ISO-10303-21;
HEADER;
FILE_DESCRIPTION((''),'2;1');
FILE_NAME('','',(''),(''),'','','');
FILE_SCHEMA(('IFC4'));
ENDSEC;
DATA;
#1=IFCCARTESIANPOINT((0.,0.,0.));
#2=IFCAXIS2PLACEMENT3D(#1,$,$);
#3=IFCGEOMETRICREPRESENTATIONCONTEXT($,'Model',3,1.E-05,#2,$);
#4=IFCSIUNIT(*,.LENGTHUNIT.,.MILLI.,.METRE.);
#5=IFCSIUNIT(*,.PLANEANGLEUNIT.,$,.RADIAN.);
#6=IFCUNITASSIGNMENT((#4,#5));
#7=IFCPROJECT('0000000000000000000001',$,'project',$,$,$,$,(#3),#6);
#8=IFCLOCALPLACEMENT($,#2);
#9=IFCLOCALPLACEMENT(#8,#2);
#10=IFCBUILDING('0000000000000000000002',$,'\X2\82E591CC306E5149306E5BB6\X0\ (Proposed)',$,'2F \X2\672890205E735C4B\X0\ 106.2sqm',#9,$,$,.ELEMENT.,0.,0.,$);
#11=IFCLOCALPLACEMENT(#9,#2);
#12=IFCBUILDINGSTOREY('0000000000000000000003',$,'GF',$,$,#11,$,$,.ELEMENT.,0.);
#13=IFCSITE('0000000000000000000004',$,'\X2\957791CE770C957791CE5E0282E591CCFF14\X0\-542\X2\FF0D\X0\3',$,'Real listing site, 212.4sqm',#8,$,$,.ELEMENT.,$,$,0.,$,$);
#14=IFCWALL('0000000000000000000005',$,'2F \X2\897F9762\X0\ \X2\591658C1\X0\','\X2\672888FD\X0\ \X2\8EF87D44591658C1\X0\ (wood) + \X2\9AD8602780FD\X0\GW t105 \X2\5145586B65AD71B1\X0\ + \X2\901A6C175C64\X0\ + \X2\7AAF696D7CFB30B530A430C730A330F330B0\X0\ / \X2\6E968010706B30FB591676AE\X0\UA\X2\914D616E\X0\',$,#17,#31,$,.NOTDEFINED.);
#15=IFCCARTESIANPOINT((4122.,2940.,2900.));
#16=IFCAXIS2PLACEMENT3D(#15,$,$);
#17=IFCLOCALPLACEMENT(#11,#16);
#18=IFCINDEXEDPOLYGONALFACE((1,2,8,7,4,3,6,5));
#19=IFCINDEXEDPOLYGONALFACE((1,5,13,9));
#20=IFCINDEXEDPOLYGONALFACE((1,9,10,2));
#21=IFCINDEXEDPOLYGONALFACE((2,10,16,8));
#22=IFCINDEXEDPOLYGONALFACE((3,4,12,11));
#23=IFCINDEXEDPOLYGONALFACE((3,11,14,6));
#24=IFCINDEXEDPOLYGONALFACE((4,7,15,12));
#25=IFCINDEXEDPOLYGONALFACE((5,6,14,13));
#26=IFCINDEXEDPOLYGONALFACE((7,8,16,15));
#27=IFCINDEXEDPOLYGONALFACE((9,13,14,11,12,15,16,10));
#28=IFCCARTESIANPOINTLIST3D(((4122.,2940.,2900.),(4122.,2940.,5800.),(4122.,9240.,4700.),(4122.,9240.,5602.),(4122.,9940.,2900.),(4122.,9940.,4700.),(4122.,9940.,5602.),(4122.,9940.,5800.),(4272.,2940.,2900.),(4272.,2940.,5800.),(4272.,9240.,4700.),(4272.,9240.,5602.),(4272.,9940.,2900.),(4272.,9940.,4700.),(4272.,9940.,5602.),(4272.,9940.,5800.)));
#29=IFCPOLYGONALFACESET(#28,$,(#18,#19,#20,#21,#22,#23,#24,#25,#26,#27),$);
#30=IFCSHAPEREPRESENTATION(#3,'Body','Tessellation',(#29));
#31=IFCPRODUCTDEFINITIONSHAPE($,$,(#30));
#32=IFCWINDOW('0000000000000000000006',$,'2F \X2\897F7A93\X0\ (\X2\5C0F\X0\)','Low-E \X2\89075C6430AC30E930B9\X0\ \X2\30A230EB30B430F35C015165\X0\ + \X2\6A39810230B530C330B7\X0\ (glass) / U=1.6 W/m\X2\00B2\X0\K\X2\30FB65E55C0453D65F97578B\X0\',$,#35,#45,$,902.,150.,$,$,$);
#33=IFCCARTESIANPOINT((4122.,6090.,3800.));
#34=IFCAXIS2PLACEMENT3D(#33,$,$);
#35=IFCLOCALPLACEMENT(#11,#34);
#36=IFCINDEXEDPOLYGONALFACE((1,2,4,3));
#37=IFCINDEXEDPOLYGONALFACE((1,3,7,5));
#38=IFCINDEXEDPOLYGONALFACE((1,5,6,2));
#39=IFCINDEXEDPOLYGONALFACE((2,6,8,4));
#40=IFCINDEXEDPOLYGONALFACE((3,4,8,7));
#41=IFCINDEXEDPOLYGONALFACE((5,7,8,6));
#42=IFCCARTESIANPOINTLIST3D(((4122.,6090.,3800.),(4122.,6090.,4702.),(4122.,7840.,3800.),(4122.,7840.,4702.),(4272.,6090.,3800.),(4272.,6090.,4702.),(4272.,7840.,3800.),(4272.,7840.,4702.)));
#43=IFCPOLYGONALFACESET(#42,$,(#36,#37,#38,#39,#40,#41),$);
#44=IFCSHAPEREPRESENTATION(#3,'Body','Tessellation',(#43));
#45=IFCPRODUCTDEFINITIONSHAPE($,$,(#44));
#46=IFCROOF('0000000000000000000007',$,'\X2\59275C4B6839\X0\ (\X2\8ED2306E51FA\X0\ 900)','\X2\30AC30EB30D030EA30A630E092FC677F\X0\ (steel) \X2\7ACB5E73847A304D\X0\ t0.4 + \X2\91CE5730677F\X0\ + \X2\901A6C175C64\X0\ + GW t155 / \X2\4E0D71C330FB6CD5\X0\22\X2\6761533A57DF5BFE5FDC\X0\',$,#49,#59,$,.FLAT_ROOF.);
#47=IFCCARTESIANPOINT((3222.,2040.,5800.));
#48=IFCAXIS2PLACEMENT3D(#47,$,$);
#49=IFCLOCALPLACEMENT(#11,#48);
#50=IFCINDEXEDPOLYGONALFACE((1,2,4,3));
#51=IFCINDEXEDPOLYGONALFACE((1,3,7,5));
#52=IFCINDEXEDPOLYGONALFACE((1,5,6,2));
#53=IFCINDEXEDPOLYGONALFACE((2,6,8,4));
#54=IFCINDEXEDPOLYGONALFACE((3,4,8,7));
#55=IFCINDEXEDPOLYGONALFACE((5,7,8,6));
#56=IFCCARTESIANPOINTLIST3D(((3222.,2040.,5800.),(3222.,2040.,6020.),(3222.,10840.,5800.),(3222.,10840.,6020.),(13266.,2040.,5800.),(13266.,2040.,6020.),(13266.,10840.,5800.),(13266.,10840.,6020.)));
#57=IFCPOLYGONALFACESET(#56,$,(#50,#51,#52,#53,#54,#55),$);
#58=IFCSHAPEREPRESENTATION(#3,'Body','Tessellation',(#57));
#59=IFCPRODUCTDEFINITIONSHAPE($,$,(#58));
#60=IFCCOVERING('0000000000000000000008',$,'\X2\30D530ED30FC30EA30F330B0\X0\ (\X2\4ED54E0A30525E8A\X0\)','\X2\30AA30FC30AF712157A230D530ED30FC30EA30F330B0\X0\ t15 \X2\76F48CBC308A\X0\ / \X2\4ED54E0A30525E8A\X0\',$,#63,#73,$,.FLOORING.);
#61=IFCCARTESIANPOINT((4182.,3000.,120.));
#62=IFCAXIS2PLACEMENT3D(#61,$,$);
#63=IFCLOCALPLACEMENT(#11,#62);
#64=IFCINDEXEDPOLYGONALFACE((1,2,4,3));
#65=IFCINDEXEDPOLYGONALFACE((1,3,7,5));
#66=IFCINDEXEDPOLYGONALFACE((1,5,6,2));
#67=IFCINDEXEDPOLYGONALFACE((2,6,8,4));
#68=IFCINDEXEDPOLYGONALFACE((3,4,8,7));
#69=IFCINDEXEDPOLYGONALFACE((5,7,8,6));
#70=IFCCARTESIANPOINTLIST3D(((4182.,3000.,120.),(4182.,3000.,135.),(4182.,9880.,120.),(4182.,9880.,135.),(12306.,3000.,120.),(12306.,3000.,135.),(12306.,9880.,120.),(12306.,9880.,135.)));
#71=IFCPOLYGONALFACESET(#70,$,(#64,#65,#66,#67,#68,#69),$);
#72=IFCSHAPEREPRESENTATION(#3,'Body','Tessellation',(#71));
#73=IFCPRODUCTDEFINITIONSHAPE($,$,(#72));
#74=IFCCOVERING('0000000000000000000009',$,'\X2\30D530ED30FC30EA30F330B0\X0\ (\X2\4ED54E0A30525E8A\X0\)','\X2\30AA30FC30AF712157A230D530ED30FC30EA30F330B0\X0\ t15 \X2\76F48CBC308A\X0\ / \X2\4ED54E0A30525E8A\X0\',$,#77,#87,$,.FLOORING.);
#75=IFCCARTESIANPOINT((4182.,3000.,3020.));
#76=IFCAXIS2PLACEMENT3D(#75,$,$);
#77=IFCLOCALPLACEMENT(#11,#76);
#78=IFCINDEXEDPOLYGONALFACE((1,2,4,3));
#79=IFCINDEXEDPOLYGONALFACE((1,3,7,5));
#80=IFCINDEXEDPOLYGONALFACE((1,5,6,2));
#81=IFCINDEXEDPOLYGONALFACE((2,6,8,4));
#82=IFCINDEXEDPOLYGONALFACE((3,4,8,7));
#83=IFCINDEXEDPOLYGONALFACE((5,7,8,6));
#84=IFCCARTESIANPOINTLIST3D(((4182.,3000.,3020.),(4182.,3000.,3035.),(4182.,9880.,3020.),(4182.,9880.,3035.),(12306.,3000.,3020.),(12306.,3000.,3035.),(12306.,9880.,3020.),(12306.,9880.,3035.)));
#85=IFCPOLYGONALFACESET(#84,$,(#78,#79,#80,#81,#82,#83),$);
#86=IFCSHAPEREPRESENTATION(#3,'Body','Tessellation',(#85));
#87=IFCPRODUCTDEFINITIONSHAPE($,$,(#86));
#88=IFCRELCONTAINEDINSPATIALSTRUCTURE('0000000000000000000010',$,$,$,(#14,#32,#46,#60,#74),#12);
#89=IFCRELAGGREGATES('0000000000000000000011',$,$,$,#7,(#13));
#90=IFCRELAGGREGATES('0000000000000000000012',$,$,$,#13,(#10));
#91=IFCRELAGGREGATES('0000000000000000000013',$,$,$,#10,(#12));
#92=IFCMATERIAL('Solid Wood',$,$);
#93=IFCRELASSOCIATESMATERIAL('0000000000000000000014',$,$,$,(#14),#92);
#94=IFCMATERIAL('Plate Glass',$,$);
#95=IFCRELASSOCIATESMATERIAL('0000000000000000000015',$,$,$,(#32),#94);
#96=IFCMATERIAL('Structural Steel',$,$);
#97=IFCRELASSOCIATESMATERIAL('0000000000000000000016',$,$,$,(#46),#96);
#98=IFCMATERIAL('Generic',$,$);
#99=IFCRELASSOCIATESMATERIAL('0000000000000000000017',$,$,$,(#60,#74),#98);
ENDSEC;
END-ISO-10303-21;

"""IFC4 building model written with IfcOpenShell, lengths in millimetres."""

from ifc_helpers import new_model, si_unit, frame, frame_2d, origin, place, context, project, spatial, rectangle, extrude, material, element, fill, save


model = new_model("IFC4")

# Units and contexts
model_context = context("Model", 3, precision=1e-05, world=origin())
ifc_project = project(units=[si_unit("LENGTHUNIT", "METRE", prefix="MILLI"), si_unit("PLANEANGLEUNIT", "RADIAN")], contexts=[model_context])

# Site, building, storey
site_placement = place(None, origin())
site = spatial("IfcSite", under=ifc_project, at=site_placement, Name="長野県長野市若里４-542－3", ObjectType="Real listing site, 212.4sqm", CompositionType="ELEMENT", RefElevation=0.0)
building_placement = place(site_placement, origin())
building = spatial("IfcBuilding", under=site, at=building_placement, Name="若里の光の家 (Proposed)", ObjectType="2F 木造平屋 106.2sqm", CompositionType="ELEMENT", ElevationOfRefHeight=0.0, ElevationOfTerrain=0.0)
storey_placement = place(building_placement, origin())
storey = spatial("IfcBuildingStorey", under=building, at=storey_placement, Name="GF", CompositionType="ELEMENT", Elevation=0.0)

# Shared definitions
ifc_material_1 = material(Name="Solid Wood")

# Shared definitions
ifc_material_2 = material(Name="Plate Glass")

# Wall, opening, window
wall_1_placement = place(storey_placement, frame((4122.0, 2940.0, 2900.0)))
wall_1 = element("IfcWall", 1, at=wall_1_placement, inside=storey, material=ifc_material_1, Name="2F 西面 外壁", Description="木製 軸組外壁 (wood) + 高性能GW t105 充填断熱 + 通気層 + 窯業系サイディング / 準耐火・外皮UA配慮", PredefinedType="NOTDEFINED", context=model_context, shape_type="SweptSolid", body=[
    extrude(rectangle(XDim=150.0, YDim=7000.0, at=frame_2d((75.0, 3500.0))), frame((4122.0, 2940.0, 2900.0)), (0.0, 0.0, 1.0), 2900.0),
])
opening_1_placement = place(storey_placement, frame((4122.0, 6090.0, 3800.0)))
opening_1 = element("IfcOpeningElement", 2, at=opening_1_placement, cuts=wall_1, PredefinedType="NOTDEFINED", context=model_context, shape_type="SweptSolid", body=[
    extrude(rectangle(XDim=150.0, YDim=1750.0, at=frame_2d((75.0, 875.0))), frame((4122.0, 6090.0, 3800.0)), (0.0, 0.0, 1.0), 902.0),
])
window_1_placement = place(storey_placement, frame((4122.0, 6090.0, 3800.0)))
window_1 = element("IfcWindow", 3, at=window_1_placement, inside=storey, material=ifc_material_2, Name="2F 西窓 (小)", Description="Low-E 複層ガラス アルゴン封入 + 樹脂サッシ (glass) / U=1.6 W/m²K・日射取得型", OverallHeight=902.0, OverallWidth=150.0, context=model_context, shape_type="SweptSolid", body=[
    extrude(rectangle(XDim=150.0, YDim=1750.0, at=frame_2d((75.0, 875.0))), frame((4122.0, 6090.0, 3800.0)), (0.0, 0.0, 1.0), 902.0),
])
fill(opening_1, window_1)

# Roof
ifc_material_3 = material(Name="Structural Steel")
roof_placement = place(storey_placement, frame((3222.0, 2040.0, 5800.0)))
element("IfcRoof", 4, at=roof_placement, inside=storey, material=ifc_material_3, Name="大屋根 (軒の出 900)", Description="ガルバリウム鋼板 (steel) 立平葺き t0.4 + 野地板 + 通気層 + GW t155 / 不燃・法22条区域対応", PredefinedType="FLAT_ROOF", context=model_context, shape_type="SweptSolid", body=[
    extrude(rectangle(XDim=10044.0, YDim=8800.0, at=frame_2d((5022.0, 4400.0))), frame((3222.0, 2040.0, 5800.0)), (0.0, 0.0, 1.0), 220.0),
])

# Coverings
ifc_material_4 = material(Name="Generic")
covering_1_placement = place(storey_placement, frame((4182.0, 3000.0, 120.0)))
element("IfcCovering", 5, at=covering_1_placement, inside=storey, material=ifc_material_4, Name="フローリング (仕上げ床)", Description="オーク無垢フローリング t15 直貼り / 仕上げ床", PredefinedType="FLOORING", context=model_context, shape_type="SweptSolid", body=[
    extrude(rectangle(XDim=8124.0, YDim=6880.0, at=frame_2d((4062.0, 3440.0))), frame((4182.0, 3000.0, 120.0)), (0.0, 0.0, 1.0), 15.0),
])
covering_2_placement = place(storey_placement, frame((4182.0, 3000.0, 3020.0)))
element("IfcCovering", 6, at=covering_2_placement, inside=storey, material=ifc_material_4, Name="フローリング (仕上げ床)", Description="オーク無垢フローリング t15 直貼り / 仕上げ床", PredefinedType="FLOORING", context=model_context, shape_type="SweptSolid", body=[
    extrude(rectangle(XDim=8124.0, YDim=6880.0, at=frame_2d((4062.0, 3440.0))), frame((4182.0, 3000.0, 3020.0)), (0.0, 0.0, 1.0), 15.0),
])

save(model, "model.ifc")
